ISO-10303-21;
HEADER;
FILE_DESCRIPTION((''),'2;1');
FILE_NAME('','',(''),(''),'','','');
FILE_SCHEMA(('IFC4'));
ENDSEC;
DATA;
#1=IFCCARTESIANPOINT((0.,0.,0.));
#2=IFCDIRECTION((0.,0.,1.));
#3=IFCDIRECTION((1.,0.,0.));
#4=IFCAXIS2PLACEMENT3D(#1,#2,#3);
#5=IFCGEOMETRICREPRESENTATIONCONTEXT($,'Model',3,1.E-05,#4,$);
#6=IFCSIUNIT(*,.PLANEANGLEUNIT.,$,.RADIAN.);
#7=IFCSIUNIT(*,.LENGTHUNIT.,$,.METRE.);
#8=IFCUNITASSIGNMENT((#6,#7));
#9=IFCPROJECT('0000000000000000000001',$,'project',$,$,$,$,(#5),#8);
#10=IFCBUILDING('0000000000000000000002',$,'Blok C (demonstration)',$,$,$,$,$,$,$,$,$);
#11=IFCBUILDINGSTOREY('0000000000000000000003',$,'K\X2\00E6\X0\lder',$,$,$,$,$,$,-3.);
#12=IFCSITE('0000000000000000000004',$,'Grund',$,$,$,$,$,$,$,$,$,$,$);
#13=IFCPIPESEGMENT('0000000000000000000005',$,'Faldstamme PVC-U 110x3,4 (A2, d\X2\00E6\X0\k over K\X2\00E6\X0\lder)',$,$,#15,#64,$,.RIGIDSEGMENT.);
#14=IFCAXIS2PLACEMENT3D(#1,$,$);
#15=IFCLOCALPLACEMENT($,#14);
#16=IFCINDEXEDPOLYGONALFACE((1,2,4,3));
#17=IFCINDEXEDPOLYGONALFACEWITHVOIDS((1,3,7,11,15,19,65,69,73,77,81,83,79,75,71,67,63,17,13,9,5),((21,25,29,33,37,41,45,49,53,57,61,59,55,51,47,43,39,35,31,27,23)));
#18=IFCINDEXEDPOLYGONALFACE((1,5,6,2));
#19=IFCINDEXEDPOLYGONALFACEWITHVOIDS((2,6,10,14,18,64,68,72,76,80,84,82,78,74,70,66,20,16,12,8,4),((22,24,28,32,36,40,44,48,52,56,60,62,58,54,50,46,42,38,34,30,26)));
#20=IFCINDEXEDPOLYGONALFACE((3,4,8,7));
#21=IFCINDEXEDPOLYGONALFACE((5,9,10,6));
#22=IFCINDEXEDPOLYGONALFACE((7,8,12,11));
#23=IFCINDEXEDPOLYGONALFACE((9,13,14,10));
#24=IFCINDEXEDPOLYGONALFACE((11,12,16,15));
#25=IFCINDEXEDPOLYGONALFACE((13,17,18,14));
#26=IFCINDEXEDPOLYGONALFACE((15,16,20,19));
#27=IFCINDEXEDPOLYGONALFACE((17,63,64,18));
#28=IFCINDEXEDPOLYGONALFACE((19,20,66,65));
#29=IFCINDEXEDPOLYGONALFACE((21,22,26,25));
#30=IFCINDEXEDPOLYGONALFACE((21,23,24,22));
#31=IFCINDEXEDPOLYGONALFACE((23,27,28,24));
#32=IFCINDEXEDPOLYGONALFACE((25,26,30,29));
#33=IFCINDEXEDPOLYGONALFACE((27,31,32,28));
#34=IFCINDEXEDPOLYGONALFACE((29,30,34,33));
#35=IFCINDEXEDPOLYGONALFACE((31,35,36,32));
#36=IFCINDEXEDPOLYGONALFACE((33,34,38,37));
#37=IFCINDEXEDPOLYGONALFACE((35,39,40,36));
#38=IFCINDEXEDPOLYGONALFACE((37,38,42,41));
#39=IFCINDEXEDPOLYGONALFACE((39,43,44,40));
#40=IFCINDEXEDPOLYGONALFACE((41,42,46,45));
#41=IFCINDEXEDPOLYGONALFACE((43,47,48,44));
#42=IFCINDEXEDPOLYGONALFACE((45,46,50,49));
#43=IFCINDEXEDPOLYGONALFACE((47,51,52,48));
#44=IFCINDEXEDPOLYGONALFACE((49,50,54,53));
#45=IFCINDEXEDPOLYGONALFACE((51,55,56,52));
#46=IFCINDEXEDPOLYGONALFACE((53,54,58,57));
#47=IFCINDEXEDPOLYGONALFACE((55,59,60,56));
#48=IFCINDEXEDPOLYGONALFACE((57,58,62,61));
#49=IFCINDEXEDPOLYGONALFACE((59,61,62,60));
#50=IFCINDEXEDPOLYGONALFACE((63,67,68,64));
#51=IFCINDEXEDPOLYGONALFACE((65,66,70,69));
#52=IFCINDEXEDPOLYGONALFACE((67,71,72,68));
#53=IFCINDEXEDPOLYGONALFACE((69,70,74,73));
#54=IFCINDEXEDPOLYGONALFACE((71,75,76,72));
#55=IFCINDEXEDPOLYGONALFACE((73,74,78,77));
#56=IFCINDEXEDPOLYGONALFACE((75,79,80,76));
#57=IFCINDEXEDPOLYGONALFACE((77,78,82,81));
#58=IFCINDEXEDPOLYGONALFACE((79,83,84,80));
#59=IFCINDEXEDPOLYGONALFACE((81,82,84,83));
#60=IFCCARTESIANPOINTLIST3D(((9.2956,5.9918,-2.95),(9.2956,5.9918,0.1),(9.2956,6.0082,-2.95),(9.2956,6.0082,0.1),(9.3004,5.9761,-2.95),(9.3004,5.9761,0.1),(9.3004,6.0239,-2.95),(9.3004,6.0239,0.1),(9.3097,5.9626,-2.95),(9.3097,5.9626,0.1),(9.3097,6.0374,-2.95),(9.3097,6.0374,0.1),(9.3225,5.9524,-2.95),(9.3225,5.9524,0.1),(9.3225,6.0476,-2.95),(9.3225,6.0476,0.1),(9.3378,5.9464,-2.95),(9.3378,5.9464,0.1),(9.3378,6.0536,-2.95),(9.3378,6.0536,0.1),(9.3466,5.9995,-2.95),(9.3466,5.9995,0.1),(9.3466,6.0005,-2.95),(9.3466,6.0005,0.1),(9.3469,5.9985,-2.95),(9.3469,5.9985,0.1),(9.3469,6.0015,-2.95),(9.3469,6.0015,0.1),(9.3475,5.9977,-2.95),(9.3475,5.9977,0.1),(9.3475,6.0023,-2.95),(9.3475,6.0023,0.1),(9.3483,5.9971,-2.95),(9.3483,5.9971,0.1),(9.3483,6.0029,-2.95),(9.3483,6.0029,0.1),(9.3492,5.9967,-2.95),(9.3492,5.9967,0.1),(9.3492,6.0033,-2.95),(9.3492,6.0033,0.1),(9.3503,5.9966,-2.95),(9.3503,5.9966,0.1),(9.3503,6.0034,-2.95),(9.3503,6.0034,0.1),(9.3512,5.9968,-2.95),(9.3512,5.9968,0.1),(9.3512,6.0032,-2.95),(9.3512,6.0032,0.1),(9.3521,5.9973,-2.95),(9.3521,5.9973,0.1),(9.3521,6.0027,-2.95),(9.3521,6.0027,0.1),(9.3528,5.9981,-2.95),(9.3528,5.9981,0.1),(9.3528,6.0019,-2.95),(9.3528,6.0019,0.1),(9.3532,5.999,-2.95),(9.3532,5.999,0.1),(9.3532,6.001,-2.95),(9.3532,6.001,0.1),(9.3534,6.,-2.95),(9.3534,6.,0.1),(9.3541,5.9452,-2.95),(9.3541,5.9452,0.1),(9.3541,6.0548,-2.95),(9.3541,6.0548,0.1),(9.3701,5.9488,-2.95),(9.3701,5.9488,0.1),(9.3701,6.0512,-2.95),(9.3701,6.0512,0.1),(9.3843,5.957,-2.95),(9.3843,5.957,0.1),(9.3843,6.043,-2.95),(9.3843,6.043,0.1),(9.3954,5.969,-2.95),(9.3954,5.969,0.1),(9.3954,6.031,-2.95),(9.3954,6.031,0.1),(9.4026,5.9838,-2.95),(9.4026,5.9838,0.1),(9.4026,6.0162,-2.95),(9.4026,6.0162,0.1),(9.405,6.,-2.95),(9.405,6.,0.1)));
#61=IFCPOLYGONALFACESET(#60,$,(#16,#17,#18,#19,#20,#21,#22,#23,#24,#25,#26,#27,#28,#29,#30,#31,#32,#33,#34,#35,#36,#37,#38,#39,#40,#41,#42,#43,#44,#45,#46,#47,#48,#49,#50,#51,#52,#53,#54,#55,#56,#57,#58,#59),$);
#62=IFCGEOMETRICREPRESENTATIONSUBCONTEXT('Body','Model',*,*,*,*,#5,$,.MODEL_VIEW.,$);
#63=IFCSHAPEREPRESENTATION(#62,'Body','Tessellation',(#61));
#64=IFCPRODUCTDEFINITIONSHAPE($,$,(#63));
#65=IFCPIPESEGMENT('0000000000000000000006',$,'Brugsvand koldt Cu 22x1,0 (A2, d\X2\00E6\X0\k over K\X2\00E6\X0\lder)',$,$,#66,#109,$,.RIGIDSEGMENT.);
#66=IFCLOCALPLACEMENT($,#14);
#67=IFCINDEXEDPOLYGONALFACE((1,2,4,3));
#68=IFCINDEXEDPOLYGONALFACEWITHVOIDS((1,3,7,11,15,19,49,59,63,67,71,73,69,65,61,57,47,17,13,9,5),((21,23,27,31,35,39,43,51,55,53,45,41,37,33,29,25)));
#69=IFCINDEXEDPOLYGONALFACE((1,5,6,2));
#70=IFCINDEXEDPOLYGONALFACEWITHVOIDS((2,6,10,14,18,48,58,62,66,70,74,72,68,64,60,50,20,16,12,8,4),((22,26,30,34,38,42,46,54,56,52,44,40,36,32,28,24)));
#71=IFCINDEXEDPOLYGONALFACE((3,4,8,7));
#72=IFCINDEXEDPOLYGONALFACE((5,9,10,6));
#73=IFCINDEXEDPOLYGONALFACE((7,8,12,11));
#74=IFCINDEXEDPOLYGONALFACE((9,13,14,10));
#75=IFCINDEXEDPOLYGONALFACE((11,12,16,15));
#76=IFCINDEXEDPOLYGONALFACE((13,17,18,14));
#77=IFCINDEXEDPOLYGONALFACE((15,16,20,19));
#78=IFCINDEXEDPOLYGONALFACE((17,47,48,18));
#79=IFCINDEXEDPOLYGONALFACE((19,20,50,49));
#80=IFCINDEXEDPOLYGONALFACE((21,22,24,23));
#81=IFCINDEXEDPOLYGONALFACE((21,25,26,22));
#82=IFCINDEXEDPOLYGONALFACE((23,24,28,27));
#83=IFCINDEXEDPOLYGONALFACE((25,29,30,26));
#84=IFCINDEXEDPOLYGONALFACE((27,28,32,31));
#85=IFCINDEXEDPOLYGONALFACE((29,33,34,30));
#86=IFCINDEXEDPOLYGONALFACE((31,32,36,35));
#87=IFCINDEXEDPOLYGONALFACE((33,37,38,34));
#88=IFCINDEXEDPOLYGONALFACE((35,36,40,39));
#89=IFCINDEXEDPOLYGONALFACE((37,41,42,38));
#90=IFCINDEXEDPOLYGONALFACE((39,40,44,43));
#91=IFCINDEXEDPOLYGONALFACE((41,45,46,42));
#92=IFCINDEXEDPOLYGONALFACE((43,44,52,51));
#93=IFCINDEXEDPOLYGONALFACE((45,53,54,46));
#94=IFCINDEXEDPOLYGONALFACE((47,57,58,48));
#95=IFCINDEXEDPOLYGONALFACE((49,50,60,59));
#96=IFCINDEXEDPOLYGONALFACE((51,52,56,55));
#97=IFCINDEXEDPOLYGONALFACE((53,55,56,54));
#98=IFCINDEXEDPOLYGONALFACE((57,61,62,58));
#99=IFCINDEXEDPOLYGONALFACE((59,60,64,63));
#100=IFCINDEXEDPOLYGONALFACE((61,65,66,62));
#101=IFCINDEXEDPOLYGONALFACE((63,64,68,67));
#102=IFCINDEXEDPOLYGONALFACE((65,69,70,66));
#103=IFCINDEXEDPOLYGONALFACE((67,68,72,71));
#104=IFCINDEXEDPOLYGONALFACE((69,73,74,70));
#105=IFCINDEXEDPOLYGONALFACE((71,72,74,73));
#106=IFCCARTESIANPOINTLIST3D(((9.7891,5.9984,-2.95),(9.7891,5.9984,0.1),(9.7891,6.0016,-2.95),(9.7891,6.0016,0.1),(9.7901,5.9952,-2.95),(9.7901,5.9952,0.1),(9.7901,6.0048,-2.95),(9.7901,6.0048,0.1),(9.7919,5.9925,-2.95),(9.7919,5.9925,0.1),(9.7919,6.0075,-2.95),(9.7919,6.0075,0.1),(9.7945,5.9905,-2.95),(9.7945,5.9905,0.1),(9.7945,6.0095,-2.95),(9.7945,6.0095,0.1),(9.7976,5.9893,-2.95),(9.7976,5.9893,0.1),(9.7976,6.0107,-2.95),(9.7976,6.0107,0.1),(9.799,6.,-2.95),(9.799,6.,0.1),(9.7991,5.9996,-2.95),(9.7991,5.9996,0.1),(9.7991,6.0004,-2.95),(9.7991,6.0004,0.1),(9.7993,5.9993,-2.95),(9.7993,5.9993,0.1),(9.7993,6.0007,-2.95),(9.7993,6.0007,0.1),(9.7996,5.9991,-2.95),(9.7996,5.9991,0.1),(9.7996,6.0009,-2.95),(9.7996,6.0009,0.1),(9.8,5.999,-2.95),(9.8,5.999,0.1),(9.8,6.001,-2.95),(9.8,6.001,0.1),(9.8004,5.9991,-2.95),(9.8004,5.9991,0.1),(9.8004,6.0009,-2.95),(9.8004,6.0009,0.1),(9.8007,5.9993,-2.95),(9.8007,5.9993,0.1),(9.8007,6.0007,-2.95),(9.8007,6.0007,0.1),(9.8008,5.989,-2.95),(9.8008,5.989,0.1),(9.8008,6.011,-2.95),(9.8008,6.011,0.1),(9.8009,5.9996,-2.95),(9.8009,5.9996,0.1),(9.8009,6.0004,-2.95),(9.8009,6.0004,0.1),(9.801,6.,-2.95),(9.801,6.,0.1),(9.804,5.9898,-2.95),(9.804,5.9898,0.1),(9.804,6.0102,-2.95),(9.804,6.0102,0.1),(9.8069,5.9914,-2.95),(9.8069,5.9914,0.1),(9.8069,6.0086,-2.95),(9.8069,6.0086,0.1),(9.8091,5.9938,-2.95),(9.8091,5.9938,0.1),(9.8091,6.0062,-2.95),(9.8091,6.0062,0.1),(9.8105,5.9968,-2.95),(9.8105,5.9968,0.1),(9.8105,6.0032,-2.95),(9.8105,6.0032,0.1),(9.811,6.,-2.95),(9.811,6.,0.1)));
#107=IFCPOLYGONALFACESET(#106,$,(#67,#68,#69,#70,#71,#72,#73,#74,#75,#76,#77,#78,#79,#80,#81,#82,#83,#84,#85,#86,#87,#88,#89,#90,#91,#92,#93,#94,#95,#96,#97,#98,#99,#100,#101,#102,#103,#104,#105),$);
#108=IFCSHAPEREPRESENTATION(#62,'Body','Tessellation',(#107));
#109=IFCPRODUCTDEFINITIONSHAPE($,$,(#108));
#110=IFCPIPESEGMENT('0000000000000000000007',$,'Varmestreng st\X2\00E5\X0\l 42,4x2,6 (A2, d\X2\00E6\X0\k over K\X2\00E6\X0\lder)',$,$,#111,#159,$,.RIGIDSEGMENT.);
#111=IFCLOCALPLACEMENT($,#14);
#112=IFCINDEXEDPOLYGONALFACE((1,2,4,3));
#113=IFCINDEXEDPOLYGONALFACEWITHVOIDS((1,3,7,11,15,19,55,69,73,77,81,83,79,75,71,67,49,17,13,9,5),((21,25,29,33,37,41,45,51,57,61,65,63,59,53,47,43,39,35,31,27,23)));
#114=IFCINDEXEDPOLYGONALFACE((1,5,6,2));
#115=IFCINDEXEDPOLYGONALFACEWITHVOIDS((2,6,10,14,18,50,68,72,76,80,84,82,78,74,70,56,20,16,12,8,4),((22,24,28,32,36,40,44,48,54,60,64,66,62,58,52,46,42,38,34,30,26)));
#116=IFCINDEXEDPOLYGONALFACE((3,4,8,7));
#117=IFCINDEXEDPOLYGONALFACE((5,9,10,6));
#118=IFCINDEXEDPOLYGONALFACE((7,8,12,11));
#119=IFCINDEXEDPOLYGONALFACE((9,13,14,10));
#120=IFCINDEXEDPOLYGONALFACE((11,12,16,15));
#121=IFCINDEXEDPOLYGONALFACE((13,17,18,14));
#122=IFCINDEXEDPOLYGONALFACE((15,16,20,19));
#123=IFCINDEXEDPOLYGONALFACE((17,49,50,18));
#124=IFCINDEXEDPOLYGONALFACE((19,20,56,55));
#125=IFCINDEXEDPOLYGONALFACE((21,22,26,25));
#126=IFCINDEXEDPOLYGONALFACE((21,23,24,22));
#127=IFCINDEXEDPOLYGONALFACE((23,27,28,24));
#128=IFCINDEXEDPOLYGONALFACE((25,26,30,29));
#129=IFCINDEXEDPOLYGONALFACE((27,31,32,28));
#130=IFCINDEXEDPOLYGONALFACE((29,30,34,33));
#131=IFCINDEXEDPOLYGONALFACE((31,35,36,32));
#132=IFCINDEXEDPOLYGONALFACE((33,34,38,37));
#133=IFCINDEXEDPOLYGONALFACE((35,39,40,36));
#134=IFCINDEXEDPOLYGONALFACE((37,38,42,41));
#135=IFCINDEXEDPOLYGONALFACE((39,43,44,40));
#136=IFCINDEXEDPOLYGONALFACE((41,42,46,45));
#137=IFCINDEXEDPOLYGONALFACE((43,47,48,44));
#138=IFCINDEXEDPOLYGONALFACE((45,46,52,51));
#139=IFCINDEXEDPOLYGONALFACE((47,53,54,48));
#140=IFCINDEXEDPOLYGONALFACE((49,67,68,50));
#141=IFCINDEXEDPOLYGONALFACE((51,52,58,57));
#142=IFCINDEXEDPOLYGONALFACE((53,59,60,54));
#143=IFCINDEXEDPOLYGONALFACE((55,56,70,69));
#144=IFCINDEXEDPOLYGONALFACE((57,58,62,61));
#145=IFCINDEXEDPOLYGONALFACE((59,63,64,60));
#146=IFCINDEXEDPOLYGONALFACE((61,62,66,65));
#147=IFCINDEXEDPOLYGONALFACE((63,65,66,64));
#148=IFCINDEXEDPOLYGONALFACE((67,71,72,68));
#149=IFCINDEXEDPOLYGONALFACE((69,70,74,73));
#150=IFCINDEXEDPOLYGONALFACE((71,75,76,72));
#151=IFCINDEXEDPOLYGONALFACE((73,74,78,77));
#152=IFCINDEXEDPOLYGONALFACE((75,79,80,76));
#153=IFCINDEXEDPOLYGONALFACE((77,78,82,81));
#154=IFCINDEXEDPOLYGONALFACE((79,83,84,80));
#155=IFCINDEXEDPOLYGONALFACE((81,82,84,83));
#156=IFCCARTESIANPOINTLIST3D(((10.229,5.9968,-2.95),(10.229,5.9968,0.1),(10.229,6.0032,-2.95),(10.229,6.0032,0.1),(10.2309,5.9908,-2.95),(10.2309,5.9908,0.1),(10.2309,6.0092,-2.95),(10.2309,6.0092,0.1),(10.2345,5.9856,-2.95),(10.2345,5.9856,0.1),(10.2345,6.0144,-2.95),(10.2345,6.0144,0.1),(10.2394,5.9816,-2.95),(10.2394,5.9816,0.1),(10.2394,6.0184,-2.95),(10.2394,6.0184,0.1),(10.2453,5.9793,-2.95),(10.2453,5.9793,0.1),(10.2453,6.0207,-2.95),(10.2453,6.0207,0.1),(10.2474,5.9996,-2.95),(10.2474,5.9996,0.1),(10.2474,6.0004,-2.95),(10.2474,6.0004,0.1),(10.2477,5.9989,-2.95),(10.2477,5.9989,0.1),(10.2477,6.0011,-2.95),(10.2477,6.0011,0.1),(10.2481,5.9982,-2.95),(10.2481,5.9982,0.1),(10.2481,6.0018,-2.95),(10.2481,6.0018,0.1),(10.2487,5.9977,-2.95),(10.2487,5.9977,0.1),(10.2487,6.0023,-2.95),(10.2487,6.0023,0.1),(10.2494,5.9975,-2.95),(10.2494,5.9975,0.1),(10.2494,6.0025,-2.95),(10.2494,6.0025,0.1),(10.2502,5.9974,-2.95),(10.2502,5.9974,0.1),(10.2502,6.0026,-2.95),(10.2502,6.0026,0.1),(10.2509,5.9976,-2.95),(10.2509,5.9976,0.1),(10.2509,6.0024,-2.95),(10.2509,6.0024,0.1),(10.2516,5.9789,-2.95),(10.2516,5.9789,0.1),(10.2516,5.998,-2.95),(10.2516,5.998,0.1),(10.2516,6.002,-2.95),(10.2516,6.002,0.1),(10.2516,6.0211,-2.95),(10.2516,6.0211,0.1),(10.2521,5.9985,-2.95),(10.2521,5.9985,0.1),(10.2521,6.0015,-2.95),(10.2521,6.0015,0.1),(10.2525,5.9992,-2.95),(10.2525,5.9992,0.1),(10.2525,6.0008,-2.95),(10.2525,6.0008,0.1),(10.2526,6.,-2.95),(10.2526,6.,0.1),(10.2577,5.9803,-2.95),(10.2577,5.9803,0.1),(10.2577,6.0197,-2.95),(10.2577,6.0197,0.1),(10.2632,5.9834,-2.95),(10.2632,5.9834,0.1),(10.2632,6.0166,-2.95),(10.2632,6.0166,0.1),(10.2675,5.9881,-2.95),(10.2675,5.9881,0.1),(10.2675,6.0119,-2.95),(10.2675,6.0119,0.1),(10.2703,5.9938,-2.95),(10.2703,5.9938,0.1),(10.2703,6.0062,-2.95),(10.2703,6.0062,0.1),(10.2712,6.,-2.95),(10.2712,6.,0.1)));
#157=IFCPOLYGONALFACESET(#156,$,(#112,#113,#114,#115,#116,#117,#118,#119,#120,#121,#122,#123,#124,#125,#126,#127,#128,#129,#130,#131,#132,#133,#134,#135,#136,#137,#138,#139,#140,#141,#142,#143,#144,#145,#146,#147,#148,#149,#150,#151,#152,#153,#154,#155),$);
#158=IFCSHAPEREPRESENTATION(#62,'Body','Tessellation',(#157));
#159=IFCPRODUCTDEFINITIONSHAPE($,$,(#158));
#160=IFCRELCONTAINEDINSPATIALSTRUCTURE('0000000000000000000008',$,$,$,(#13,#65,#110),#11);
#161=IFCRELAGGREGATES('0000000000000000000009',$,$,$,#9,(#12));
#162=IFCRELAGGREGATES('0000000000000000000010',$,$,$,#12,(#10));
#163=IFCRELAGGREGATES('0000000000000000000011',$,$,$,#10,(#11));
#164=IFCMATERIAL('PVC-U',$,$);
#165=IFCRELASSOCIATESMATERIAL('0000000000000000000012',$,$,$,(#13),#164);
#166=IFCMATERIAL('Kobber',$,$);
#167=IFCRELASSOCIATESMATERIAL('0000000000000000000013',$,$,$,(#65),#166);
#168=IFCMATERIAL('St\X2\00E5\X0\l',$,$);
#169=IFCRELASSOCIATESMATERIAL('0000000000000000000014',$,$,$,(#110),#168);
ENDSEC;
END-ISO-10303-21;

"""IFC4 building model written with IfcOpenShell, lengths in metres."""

from ifc_helpers import new_model, si_unit, frame, origin_with_axes, place, context, subcontext, project, spatial, hollow_circle, extrude, material, element, save


model = new_model("IFC4")

# Units and contexts
model_context = context("Model", 3, precision=1e-05, world=origin_with_axes())
body_context = subcontext(model_context, "Body", "Model", "MODEL_VIEW")
ifc_project = project(units=[si_unit("PLANEANGLEUNIT", "RADIAN"), si_unit("LENGTHUNIT", "METRE")], contexts=[model_context])

# Site, building, storey
site = spatial("IfcSite", under=ifc_project, Name="Grund")
building = spatial("IfcBuilding", under=site, Name="Blok C (demonstration)")
storey = spatial("IfcBuildingStorey", under=building, Name="Kælder", Elevation=-3.0)

# Pipe segments
ifc_material_1 = material(Name="PVC-U")
ifc_material_2 = material(Name="Kobber")
ifc_material_3 = material(Name="Stål")
pipe_segment_1_placement = place(None, origin_with_axes())
element("IfcPipeSegment", 1, at=pipe_segment_1_placement, inside=storey, material=ifc_material_1, Name="Faldstamme PVC-U 110x3,4 (A2, dæk over Kælder)", PredefinedType="RIGIDSEGMENT", context=body_context, shape_type="SweptSolid", body=[
    extrude(hollow_circle(Radius=0.055, WallThickness=0.0516), frame((9.35, 6.0, -2.95), z_axis=(0.0, 0.0, 1.0), x_axis=(1.0, 0.0, 0.0)), (0.0, 0.0, 1.0), 3.05),
])
pipe_segment_2_placement = place(None, origin_with_axes())
element("IfcPipeSegment", 2, at=pipe_segment_2_placement, inside=storey, material=ifc_material_2, Name="Brugsvand koldt Cu 22x1,0 (A2, dæk over Kælder)", PredefinedType="RIGIDSEGMENT", context=body_context, shape_type="SweptSolid", body=[
    extrude(hollow_circle(Radius=0.011, WallThickness=0.01), frame((9.8, 6.0, -2.95), z_axis=(0.0, 0.0, 1.0), x_axis=(1.0, 0.0, 0.0)), (0.0, 0.0, 1.0), 3.05),
])
pipe_segment_3_placement = place(None, origin_with_axes())
element("IfcPipeSegment", 3, at=pipe_segment_3_placement, inside=storey, material=ifc_material_3, Name="Varmestreng stål 42,4x2,6 (A2, dæk over Kælder)", PredefinedType="RIGIDSEGMENT", context=body_context, shape_type="SweptSolid", body=[
    extrude(hollow_circle(Radius=0.0212, WallThickness=0.0186), frame((10.25, 6.0, -2.95), z_axis=(0.0, 0.0, 1.0), x_axis=(1.0, 0.0, 0.0)), (0.0, 0.0, 1.0), 3.05),
])

save(model, "model.ifc")
